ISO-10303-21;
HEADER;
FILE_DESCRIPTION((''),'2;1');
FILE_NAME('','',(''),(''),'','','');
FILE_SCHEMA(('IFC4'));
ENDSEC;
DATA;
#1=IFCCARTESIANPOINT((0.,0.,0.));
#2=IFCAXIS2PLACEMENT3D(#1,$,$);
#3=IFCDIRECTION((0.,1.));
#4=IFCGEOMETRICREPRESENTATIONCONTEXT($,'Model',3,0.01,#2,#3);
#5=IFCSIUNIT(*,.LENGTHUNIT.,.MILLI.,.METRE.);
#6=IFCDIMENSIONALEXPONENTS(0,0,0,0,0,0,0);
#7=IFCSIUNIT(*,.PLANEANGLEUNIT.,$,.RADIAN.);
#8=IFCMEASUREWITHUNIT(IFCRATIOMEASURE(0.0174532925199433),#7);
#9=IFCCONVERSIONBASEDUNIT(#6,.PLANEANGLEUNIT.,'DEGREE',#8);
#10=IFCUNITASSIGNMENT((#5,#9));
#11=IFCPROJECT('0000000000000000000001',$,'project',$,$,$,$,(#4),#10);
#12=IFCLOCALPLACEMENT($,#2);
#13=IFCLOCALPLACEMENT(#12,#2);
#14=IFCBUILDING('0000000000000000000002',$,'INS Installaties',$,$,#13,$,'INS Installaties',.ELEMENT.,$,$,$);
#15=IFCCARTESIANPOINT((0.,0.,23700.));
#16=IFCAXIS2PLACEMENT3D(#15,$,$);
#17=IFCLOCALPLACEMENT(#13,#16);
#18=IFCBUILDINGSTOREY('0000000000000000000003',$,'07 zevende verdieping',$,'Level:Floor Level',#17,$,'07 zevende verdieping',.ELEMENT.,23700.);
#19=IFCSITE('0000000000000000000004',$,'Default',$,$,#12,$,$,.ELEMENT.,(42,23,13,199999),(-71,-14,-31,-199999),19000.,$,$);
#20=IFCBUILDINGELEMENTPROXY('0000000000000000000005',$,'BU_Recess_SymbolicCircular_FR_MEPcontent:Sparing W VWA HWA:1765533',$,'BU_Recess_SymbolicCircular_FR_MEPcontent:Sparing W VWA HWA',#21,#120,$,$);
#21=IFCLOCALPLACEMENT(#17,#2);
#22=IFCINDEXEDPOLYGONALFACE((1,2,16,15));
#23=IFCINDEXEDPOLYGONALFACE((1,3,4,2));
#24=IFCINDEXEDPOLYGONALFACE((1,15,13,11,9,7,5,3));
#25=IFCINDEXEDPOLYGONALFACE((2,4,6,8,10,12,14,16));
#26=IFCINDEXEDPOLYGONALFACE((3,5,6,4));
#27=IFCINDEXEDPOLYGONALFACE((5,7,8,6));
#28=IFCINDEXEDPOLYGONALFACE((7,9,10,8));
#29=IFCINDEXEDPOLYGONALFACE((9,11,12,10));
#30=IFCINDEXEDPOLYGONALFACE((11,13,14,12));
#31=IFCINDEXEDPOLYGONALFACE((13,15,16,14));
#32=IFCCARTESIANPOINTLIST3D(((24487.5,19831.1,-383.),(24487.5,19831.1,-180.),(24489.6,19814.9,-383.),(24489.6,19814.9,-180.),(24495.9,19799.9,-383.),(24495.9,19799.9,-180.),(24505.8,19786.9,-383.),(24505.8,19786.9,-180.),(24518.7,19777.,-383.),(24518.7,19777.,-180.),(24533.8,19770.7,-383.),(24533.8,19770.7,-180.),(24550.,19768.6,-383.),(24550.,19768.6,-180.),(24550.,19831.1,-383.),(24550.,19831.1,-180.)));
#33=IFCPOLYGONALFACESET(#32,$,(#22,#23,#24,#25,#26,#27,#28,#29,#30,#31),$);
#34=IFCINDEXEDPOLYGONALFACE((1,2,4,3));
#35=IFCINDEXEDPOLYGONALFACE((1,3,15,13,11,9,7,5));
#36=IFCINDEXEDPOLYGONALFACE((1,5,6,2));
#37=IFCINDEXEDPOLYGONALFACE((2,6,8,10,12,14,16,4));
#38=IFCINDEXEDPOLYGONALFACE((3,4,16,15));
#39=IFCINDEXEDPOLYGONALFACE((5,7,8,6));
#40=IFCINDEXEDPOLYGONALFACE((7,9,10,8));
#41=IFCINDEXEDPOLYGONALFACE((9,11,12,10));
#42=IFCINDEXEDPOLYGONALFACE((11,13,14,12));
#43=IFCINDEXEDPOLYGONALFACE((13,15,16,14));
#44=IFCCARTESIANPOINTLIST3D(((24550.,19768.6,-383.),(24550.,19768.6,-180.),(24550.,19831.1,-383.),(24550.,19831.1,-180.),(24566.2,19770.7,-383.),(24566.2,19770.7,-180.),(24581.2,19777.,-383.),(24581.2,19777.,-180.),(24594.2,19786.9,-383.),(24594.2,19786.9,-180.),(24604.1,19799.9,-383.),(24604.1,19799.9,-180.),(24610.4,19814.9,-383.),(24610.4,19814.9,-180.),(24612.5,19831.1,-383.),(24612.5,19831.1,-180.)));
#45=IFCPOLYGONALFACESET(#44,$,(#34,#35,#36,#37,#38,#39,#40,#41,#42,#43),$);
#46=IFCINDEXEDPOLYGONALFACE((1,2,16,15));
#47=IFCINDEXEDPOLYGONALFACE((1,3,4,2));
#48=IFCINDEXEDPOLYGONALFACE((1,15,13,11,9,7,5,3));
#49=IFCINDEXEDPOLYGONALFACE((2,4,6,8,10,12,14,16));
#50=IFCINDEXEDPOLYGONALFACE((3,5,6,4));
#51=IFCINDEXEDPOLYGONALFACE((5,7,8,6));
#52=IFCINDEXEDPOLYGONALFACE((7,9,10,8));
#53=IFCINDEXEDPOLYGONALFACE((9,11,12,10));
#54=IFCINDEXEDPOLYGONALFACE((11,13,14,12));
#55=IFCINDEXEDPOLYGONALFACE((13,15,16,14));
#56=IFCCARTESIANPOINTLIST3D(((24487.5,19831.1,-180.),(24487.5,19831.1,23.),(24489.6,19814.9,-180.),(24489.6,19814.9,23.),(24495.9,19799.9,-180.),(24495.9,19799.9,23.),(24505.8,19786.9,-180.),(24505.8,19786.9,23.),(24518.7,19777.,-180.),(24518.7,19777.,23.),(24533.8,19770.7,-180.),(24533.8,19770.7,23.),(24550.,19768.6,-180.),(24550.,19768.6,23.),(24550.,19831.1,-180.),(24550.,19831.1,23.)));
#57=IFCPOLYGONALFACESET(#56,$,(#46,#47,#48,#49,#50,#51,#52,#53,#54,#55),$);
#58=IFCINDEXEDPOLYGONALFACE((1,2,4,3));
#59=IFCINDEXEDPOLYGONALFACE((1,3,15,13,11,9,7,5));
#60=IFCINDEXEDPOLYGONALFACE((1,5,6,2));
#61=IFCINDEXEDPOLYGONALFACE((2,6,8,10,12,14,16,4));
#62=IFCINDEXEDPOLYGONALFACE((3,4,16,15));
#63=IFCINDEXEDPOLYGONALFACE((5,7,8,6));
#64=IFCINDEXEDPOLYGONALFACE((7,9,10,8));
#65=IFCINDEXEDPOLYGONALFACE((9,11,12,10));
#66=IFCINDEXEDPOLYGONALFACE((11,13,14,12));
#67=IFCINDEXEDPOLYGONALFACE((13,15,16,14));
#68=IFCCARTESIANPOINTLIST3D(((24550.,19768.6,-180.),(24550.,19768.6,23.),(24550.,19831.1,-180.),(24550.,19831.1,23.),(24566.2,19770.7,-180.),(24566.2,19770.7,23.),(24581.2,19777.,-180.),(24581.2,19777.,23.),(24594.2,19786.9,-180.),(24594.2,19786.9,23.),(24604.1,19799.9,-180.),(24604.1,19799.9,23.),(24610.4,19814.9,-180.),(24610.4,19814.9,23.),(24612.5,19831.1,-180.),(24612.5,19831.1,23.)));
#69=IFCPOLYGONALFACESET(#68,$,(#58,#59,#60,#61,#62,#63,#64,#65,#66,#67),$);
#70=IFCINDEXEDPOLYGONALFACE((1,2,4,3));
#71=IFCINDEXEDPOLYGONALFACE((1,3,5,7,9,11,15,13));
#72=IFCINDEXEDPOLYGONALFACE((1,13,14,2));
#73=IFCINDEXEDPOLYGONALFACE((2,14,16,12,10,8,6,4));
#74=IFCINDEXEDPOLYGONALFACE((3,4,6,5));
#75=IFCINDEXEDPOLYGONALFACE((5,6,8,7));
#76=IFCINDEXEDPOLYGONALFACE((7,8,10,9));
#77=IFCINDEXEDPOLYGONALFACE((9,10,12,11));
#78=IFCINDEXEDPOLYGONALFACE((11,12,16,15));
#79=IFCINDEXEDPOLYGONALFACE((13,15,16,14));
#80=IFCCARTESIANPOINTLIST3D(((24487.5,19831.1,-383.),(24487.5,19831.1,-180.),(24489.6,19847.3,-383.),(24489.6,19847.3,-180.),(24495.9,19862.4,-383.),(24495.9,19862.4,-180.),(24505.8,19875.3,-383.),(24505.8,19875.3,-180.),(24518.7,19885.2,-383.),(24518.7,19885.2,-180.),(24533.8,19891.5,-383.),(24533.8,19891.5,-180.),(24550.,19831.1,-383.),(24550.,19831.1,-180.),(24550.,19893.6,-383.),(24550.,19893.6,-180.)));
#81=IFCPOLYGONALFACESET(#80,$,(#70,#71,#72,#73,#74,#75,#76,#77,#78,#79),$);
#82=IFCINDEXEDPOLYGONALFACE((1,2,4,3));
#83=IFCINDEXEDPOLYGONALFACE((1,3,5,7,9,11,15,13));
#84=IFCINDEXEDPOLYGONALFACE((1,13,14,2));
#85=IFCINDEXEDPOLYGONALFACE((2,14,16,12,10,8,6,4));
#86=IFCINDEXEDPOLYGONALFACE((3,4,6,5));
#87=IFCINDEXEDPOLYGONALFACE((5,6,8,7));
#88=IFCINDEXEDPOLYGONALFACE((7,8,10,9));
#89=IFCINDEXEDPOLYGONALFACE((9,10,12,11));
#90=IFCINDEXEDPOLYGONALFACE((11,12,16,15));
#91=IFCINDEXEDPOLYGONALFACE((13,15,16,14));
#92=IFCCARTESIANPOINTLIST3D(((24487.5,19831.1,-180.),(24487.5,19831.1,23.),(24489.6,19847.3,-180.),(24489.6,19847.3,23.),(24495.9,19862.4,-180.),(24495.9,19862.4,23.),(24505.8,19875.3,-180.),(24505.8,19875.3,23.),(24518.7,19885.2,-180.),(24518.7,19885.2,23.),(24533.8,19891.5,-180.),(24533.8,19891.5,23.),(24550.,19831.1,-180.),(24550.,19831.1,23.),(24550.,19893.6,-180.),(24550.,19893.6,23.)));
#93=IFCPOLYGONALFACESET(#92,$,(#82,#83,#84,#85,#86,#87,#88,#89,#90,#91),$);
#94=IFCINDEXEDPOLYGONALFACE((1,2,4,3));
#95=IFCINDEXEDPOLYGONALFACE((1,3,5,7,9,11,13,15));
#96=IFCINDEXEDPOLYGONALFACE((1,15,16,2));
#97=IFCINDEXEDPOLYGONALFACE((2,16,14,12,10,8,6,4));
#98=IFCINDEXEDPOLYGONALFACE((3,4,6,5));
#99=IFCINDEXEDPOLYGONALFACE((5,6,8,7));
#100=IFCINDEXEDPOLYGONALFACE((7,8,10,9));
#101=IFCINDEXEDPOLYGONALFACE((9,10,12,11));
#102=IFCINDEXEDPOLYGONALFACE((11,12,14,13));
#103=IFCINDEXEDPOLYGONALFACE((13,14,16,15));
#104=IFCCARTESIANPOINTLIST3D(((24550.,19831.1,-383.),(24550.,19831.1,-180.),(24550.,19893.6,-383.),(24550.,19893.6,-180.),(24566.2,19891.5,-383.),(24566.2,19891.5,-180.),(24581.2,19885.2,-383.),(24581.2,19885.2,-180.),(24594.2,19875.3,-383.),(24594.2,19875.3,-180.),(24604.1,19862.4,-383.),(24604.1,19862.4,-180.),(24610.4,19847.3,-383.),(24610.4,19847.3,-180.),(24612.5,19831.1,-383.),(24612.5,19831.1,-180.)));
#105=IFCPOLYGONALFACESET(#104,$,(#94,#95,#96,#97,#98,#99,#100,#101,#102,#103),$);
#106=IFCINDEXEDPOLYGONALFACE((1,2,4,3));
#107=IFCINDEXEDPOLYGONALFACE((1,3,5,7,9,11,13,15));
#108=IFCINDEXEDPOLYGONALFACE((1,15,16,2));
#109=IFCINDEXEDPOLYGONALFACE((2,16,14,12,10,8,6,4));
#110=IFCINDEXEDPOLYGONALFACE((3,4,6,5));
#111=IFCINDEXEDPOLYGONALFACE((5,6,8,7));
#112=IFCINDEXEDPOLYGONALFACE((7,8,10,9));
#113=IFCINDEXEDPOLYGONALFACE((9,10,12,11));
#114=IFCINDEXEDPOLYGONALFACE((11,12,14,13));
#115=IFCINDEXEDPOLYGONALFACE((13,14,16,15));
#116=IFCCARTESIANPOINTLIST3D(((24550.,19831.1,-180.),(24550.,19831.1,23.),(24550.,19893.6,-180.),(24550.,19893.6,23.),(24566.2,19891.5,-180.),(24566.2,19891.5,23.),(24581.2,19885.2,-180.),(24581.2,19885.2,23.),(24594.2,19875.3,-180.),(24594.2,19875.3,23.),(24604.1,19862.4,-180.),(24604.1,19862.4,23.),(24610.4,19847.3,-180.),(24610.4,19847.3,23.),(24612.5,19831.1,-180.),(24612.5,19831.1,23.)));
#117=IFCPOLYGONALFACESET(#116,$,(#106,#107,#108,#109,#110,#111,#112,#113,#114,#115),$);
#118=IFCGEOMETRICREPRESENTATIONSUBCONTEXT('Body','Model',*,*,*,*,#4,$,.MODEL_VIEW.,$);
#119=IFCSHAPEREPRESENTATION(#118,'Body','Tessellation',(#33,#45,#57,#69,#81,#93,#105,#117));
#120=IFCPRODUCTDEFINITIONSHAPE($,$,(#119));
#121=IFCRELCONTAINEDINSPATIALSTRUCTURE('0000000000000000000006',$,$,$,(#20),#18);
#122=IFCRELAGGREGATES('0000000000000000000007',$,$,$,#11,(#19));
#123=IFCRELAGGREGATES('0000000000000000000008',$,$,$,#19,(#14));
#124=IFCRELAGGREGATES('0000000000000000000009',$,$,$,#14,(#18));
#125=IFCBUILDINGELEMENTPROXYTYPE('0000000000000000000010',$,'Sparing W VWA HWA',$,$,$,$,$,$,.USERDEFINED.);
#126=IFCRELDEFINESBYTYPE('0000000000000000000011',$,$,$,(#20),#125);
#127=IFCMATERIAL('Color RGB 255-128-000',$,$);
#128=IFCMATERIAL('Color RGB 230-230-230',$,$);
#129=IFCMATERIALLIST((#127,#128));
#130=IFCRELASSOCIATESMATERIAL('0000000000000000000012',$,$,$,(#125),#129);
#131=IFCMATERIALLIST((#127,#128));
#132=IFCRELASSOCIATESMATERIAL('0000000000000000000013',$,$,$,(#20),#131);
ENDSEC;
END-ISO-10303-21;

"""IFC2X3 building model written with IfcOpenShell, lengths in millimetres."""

from ifc_helpers import new_model, entity, si_unit, converted_unit, direction, frame, frame_2d, origin, place, context, subcontext, project, spatial, polyline, circle_curve, parameter, trimmed, segment, composite_curve, outline, extrude, source, transform, mapped, material, material_list, type_object, type_shapes, element, save


model = new_model("IFC2X3")

# Units and contexts
model_context = context("Model", 3, precision=0.01, world=origin(), true_north=direction((0.0, 1.0)))
body_context = subcontext(model_context, "Body", "Model", "MODEL_VIEW")
ifc_project = project(units=[si_unit("LENGTHUNIT", "METRE", prefix="MILLI"), converted_unit("PLANEANGLEUNIT", "DEGREE", entity("IfcRatioMeasure", 0.0174532925199433), si_unit("PLANEANGLEUNIT", "RADIAN"), dimensions=[0, 0, 0, 0, 0, 0, 0])], contexts=[model_context])

# Site, building, storey
site_placement = place(None, origin())
site = spatial("IfcSite", under=ifc_project, at=site_placement, Name="Default", CompositionType="ELEMENT", RefLatitude=(42, 23, 13, 199999), RefLongitude=(-71, -14, -31, -199999), RefElevation=19000.0)
building_placement = place(site_placement, origin())
building = spatial("IfcBuilding", under=site, at=building_placement, Name="INS Installaties", LongName="INS Installaties", CompositionType="ELEMENT")
storey_placement = place(building_placement, frame((0.0, 0.0, 23700.0)))
storey = spatial("IfcBuildingStorey", under=building, at=storey_placement, Name="07 zevende verdieping", ObjectType="Level:Floor Level", LongName="07 zevende verdieping", CompositionType="ELEMENT", Elevation=23700.0)

# Building element proxy
ifc_material_1 = material(Name="Color RGB 255-128-000")
ifc_material_2 = material(Name="Color RGB 230-230-230")
ifc_material_list_1 = material_list([ifc_material_1, ifc_material_2])
building_element_proxy_type_1 = type_object("IfcBuildingElementProxyType", Name="Sparing W VWA HWA", PredefinedType="USERDEFINED", material=ifc_material_list_1)
shared_shape_1 = source(origin(), body_context, "Body", "SweptSolid", [
    extrude(outline(composite_curve([segment(trimmed(circle_curve(frame_2d((20.8, 20.8), x_axis=(1.0, 0.0)), 62.5), [parameter(180.0)], [parameter(270.0)], True, "PARAMETER"), True, "CONTINUOUS"), segment(polyline([(20.8, -41.7), (20.8, 20.8)]), True, "CONTINUOUS"), segment(polyline([(20.8, 20.8), (-41.7, 20.8)]), True, "CONTINUOUS")], self_intersect=False)), frame((20.8, 20.8, -403.0), z_axis=(0.0, 0.0, 1.0), x_axis=(-1.0, 0.0, 0.0)), (0.0, 0.0, 1.0), 203.0),
    extrude(outline(composite_curve([segment(polyline([(-41.7, -20.8), (20.8, -20.8)]), True, "CONTINUOUS"), segment(polyline([(20.8, -20.8), (20.8, 41.7)]), True, "CONTINUOUS"), segment(trimmed(circle_curve(frame_2d((20.8, -20.8), x_axis=(1.0, 0.0)), 62.5), [parameter(90.0)], [parameter(180.0)], True, "PARAMETER"), True, "CONTINUOUS")], self_intersect=False)), frame((-20.8, 20.8, -403.0)), (0.0, 0.0, 1.0), 203.0),
    extrude(outline(composite_curve([segment(trimmed(circle_curve(frame_2d((20.8, 20.8), x_axis=(1.0, 0.0)), 62.5), [parameter(180.0)], [parameter(270.0)], True, "PARAMETER"), True, "CONTINUOUS"), segment(polyline([(20.8, -41.7), (20.8, 20.8)]), True, "CONTINUOUS"), segment(polyline([(20.8, 20.8), (-41.7, 20.8)]), True, "CONTINUOUS")], self_intersect=False)), frame((20.8, 20.8, -200.0), z_axis=(0.0, 0.0, 1.0), x_axis=(-1.0, 0.0, 0.0)), (0.0, 0.0, 1.0), 203.0),
    extrude(outline(composite_curve([segment(polyline([(-41.7, -20.8), (20.8, -20.8)]), True, "CONTINUOUS"), segment(polyline([(20.8, -20.8), (20.8, 41.7)]), True, "CONTINUOUS"), segment(trimmed(circle_curve(frame_2d((20.8, -20.8), x_axis=(1.0, 0.0)), 62.5), [parameter(90.0)], [parameter(180.0)], True, "PARAMETER"), True, "CONTINUOUS")], self_intersect=False)), frame((-20.8, 20.8, -200.0)), (0.0, 0.0, 1.0), 203.0),
    extrude(outline(composite_curve([segment(polyline([(-41.7, -20.8), (20.8, -20.8)]), True, "CONTINUOUS"), segment(polyline([(20.8, -20.8), (20.8, 41.7)]), True, "CONTINUOUS"), segment(trimmed(circle_curve(frame_2d((20.8, -20.8), x_axis=(1.0, 0.0)), 62.5), [parameter(90.0)], [parameter(180.0)], True, "PARAMETER"), True, "CONTINUOUS")], self_intersect=False)), frame((20.8, -20.8, -403.0), z_axis=(0.0, 0.0, 1.0), x_axis=(-1.0, 0.0, 0.0)), (0.0, 0.0, 1.0), 203.0),
    extrude(outline(composite_curve([segment(polyline([(-41.7, -20.8), (20.8, -20.8)]), True, "CONTINUOUS"), segment(polyline([(20.8, -20.8), (20.8, 41.7)]), True, "CONTINUOUS"), segment(trimmed(circle_curve(frame_2d((20.8, -20.8), x_axis=(1.0, 0.0)), 62.5), [parameter(90.0)], [parameter(180.0)], True, "PARAMETER"), True, "CONTINUOUS")], self_intersect=False)), frame((20.8, -20.8, -200.0), z_axis=(0.0, 0.0, 1.0), x_axis=(-1.0, 0.0, 0.0)), (0.0, 0.0, 1.0), 203.0),
    extrude(outline(composite_curve([segment(trimmed(circle_curve(frame_2d((20.8, 20.8), x_axis=(1.0, 0.0)), 62.5), [parameter(180.0)], [parameter(270.0)], True, "PARAMETER"), True, "CONTINUOUS"), segment(polyline([(20.8, -41.7), (20.8, 20.8)]), True, "CONTINUOUS"), segment(polyline([(20.8, 20.8), (-41.7, 20.8)]), True, "CONTINUOUS")], self_intersect=False)), frame((-20.8, -20.8, -403.0)), (0.0, 0.0, 1.0), 203.0),
    extrude(outline(composite_curve([segment(trimmed(circle_curve(frame_2d((20.8, 20.8), x_axis=(1.0, 0.0)), 62.5), [parameter(180.0)], [parameter(270.0)], True, "PARAMETER"), True, "CONTINUOUS"), segment(polyline([(20.8, -41.7), (20.8, 20.8)]), True, "CONTINUOUS"), segment(polyline([(20.8, 20.8), (-41.7, 20.8)]), True, "CONTINUOUS")], self_intersect=False)), frame((-20.8, -20.8, -200.0)), (0.0, 0.0, 1.0), 203.0),
])
type_shapes(building_element_proxy_type_1, [shared_shape_1])
ifc_material_list_2 = material_list([ifc_material_1, ifc_material_2])
proxy_1_placement = place(storey_placement, frame((24550.0, 19831.1, 20.0), z_axis=(0.0, 0.0, 1.0), x_axis=(-1.0, 0.0, 0.0)))
element("IfcBuildingElementProxy", 1, at=proxy_1_placement, inside=storey, type_object=building_element_proxy_type_1, material=ifc_material_list_2, Name="BU_Recess_SymbolicCircular_FR_MEPcontent:Sparing W VWA HWA:1765533", ObjectType="BU_Recess_SymbolicCircular_FR_MEPcontent:Sparing W VWA HWA", context=body_context, shape_type="MappedRepresentation", body=[
    mapped(shared_shape_1, transform((0.0, 0.0, 0.0), scale=1.0)),
])

save(model, "model.ifc")
